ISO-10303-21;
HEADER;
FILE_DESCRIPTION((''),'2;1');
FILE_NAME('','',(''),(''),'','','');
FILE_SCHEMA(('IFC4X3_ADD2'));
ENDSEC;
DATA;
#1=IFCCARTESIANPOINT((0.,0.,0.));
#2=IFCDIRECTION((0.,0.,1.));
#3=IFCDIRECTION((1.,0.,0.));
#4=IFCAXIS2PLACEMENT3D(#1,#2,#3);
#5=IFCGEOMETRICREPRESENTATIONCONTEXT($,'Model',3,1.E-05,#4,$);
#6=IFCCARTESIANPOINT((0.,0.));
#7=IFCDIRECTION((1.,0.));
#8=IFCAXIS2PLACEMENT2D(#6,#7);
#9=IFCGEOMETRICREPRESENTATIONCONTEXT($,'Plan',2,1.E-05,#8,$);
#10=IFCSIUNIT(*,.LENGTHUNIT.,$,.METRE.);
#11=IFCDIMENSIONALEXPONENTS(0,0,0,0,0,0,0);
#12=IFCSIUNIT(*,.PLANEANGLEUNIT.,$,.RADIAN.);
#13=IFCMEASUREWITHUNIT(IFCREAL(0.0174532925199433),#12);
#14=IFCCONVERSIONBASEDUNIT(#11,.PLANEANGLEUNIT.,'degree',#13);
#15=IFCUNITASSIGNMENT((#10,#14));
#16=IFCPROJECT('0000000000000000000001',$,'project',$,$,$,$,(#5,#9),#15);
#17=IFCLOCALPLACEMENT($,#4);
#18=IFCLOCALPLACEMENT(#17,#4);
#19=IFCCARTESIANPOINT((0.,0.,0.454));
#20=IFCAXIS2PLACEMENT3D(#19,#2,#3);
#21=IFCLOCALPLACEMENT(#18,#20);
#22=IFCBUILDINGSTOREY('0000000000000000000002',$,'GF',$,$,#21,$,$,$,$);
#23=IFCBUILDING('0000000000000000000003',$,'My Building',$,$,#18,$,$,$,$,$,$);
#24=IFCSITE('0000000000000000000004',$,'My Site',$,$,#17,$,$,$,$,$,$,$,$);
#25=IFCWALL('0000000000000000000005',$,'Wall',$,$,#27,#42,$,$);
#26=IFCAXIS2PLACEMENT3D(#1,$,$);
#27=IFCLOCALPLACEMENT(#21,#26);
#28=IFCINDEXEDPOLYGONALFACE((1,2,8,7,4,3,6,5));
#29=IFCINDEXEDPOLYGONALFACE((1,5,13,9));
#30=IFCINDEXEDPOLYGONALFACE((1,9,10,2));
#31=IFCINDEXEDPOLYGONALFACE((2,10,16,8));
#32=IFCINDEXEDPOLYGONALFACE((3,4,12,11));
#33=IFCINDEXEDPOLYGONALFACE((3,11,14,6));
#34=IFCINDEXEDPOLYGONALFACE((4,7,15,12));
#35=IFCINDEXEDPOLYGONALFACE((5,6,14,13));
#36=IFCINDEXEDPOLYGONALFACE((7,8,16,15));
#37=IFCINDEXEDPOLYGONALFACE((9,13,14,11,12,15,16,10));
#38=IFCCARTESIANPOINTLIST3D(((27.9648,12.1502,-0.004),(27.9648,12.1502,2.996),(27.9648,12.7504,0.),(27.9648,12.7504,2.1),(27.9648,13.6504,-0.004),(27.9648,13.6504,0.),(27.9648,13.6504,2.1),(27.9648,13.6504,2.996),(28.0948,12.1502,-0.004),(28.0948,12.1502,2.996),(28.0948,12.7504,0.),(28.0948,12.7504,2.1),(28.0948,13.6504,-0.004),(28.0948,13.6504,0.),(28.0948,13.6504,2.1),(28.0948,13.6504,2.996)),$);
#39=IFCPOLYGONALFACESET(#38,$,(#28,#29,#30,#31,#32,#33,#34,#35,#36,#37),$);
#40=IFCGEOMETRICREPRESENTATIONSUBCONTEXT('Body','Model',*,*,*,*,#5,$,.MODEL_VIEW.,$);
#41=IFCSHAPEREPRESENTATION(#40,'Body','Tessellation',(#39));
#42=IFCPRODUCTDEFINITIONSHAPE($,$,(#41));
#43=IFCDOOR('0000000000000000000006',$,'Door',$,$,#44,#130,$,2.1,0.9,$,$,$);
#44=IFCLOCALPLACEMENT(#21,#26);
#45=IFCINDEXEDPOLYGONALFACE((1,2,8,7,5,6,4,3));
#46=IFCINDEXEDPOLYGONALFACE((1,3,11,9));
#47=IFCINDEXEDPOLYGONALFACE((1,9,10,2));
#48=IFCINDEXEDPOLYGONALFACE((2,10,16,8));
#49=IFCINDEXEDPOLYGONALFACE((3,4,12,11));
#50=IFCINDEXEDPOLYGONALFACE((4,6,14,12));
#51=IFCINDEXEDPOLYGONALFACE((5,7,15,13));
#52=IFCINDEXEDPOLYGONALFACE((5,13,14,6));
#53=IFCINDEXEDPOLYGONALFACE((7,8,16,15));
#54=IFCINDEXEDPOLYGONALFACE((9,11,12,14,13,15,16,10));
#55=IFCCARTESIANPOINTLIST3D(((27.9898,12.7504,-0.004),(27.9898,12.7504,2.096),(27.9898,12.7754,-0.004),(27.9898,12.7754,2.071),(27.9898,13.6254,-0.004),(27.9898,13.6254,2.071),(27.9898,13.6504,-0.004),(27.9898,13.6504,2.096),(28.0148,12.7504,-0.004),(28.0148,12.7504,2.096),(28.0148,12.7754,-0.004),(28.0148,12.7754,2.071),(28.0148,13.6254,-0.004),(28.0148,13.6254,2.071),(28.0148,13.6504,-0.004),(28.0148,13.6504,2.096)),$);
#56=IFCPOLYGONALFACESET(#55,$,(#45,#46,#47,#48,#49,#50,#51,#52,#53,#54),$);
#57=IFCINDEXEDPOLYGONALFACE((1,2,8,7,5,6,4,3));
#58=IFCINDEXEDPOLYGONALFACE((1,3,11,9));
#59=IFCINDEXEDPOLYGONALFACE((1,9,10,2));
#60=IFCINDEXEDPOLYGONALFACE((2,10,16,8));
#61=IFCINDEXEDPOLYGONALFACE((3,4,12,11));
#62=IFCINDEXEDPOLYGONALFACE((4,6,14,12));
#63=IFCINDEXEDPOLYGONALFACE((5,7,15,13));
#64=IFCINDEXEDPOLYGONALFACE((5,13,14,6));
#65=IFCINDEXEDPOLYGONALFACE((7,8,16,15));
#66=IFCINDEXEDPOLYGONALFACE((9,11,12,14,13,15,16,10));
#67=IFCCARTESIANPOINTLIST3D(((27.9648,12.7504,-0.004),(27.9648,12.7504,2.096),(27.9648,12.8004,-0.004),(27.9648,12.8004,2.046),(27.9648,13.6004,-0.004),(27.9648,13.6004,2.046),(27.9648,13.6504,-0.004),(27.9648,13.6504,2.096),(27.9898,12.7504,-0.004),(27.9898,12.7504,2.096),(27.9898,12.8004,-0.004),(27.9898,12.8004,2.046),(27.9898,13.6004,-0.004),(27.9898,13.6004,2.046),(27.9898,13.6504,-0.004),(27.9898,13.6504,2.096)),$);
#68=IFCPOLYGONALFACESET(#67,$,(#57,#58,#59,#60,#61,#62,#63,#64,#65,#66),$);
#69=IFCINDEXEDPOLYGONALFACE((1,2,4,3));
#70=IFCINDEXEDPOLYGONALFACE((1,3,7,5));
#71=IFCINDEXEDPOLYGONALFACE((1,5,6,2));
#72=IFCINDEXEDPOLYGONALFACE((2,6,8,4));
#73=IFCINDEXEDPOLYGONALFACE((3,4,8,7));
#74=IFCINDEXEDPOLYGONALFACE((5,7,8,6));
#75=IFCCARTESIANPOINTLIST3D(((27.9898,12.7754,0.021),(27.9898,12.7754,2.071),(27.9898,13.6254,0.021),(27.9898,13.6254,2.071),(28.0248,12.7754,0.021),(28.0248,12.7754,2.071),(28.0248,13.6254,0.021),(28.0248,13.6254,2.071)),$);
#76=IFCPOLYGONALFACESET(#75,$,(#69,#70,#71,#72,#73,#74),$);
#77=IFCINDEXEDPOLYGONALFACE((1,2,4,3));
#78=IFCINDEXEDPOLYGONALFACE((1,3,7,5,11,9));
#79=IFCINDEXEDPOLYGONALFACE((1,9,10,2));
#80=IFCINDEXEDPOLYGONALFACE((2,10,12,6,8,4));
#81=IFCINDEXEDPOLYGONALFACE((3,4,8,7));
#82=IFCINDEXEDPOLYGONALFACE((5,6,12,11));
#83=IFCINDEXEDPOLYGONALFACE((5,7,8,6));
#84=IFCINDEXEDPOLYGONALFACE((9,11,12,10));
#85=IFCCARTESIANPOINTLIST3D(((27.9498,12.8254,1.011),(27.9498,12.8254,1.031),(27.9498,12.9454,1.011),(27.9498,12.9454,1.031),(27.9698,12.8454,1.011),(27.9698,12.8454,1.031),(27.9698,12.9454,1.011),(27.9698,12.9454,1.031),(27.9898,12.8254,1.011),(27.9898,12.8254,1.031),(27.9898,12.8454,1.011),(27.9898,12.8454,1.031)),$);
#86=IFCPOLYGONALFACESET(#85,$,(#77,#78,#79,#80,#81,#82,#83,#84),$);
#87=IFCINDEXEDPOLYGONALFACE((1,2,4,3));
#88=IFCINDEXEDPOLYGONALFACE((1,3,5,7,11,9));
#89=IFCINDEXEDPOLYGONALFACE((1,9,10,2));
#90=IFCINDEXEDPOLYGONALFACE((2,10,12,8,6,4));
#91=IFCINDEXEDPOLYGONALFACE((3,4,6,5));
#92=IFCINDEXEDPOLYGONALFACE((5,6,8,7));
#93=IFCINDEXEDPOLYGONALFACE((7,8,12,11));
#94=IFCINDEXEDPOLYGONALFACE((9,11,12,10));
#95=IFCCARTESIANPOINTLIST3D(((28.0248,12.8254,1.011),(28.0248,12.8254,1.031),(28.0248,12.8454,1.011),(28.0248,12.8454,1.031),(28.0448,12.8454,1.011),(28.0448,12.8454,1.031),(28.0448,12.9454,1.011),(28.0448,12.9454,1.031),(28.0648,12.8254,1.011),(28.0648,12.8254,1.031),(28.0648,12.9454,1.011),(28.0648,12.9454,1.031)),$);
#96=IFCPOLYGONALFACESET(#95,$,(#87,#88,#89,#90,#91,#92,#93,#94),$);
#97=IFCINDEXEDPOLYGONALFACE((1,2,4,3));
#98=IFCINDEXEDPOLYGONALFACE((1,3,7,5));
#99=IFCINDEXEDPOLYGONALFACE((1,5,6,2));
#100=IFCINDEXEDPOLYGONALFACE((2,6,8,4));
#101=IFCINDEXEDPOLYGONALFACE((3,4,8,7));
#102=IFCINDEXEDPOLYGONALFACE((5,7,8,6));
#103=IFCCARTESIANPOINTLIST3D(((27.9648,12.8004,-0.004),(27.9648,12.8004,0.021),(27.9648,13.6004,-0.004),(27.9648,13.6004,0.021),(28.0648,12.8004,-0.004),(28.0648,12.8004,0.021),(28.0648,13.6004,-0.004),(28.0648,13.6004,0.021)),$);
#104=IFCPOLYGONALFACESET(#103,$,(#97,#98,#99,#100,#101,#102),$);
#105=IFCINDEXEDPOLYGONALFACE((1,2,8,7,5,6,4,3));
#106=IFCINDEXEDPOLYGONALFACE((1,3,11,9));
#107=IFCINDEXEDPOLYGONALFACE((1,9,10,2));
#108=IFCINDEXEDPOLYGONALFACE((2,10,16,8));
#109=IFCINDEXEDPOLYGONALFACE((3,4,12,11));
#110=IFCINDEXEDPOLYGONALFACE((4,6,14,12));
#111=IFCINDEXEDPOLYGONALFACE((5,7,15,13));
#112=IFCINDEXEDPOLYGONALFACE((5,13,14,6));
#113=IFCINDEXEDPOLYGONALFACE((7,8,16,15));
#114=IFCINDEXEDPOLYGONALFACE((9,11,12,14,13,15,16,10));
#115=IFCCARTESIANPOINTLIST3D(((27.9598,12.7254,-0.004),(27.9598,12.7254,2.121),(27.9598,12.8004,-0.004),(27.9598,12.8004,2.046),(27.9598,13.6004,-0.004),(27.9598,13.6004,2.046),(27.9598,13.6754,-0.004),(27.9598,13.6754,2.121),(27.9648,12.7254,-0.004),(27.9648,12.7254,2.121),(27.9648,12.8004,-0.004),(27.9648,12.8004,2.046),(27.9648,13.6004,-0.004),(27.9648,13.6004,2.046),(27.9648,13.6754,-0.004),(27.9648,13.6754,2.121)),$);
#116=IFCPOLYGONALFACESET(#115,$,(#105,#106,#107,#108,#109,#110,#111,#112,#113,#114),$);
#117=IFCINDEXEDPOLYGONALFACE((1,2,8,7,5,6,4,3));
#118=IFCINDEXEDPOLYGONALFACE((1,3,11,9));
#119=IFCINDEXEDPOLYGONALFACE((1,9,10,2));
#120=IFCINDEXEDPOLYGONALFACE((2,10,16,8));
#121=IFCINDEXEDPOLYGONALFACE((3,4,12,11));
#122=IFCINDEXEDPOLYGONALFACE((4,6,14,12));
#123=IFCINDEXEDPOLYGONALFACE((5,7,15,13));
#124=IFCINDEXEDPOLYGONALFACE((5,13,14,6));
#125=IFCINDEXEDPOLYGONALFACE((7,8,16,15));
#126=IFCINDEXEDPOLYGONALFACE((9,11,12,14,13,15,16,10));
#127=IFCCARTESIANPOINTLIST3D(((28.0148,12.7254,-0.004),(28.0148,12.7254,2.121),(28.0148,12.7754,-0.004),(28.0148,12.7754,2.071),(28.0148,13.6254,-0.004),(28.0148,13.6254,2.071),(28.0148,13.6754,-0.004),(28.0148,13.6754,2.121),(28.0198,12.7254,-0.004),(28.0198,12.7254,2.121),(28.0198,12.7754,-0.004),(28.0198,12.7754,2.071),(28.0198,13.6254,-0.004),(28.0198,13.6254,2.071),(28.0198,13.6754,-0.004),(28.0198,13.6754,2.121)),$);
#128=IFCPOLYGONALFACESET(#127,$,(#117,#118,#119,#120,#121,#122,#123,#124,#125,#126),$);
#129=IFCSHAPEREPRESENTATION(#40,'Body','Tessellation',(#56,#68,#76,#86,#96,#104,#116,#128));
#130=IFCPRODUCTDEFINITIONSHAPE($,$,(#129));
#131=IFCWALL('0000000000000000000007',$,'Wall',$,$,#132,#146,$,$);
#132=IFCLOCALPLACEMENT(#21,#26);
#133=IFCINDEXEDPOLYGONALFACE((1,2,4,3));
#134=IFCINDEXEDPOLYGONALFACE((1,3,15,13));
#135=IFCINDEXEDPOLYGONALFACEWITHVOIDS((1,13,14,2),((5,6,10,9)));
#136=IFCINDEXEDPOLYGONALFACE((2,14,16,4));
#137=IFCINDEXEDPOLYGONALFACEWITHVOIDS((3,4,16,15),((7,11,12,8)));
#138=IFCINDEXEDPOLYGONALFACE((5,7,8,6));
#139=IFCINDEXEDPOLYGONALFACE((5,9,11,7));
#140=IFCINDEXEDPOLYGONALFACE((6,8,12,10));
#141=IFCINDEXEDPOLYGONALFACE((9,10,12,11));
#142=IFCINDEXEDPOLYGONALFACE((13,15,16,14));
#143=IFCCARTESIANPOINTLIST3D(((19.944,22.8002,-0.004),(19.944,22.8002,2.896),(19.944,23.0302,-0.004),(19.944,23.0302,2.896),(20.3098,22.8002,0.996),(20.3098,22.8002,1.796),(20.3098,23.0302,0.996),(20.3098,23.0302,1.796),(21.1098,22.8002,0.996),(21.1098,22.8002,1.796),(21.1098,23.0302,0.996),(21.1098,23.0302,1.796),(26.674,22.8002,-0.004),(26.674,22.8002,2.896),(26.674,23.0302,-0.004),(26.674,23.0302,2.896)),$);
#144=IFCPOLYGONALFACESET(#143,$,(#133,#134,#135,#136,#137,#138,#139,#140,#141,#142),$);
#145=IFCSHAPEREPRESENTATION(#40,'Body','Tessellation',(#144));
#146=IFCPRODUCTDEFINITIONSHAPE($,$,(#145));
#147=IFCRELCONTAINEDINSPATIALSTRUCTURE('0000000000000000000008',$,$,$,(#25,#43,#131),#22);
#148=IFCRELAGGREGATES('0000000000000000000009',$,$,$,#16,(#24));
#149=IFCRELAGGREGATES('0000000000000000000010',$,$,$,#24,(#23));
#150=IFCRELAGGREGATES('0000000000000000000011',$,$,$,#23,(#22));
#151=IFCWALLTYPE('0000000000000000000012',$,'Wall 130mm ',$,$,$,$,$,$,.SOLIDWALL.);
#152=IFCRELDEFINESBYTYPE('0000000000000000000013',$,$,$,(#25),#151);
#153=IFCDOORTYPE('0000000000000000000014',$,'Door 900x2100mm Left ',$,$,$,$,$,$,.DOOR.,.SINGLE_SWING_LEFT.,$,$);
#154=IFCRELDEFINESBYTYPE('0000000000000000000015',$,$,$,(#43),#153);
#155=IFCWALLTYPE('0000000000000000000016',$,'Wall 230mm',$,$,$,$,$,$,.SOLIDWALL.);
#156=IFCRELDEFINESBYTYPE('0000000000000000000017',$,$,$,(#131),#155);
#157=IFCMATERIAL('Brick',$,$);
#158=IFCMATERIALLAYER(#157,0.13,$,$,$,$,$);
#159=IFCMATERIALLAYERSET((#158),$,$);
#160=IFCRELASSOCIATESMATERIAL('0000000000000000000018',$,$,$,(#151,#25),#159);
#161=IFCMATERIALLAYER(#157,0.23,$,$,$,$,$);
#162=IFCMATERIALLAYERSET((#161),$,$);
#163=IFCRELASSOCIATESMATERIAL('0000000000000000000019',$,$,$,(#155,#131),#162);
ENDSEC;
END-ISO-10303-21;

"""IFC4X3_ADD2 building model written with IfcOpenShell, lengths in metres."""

from ifc_helpers import new_model, entity, si_unit, converted_unit, frame, origin_with_axes, origin_2d_with_axis, place, context, subcontext, project, spatial, line, indexed_curve, outline, extrude, shape, source, transform, mapped, material, layer, layer_set, layer_usage, type_object, type_shapes, element, fill, save


model = new_model("IFC4X3_ADD2")

# Units and contexts
model_context = context("Model", 3, precision=1e-05, world=origin_with_axes())
plan_context = context("Plan", 2, precision=1e-05, world=origin_2d_with_axis())
body_context_1 = subcontext(model_context, "Body", "Model", "MODEL_VIEW")
body_context_2 = subcontext(plan_context, "Body", "Plan", "PLAN_VIEW")
ifc_project = project(units=[si_unit("LENGTHUNIT", "METRE"), converted_unit("PLANEANGLEUNIT", "degree", entity("IfcReal", 0.0174532925199433), si_unit("PLANEANGLEUNIT", "RADIAN"), dimensions=[0, 0, 0, 0, 0, 0, 0])], contexts=[model_context, plan_context])

# Site, building, storey
site_placement = place(None, origin_with_axes())
site = spatial("IfcSite", under=ifc_project, at=site_placement, Name="My Site")
building_placement = place(site_placement, origin_with_axes())
building = spatial("IfcBuilding", under=site, at=building_placement, Name="My Building")
storey_placement = place(building_placement, frame((0.0, 0.0, 0.454), z_axis=(0.0, 0.0, 1.0), x_axis=(1.0, 0.0, 0.0)))
storey = spatial("IfcBuildingStorey", under=building, at=storey_placement, Name="GF")

# Shared definitions
ifc_material_1 = material(Name="Brick")
ifc_layer_1 = layer(ifc_material_1, 0.13)
ifc_layer_set_1 = layer_set([ifc_layer_1])
wall_type_1 = type_object("IfcWallType", Name="Wall 130mm ", PredefinedType="SOLIDWALL", material=ifc_layer_set_1)

# Wall, opening, door
ifc_layer_usage_1 = layer_usage(ifc_layer_set_1, "AXIS2", "POSITIVE", 0.0)
wall_1_placement = place(storey_placement, frame((27.9648, 13.6504, -0.004), z_axis=(0.0, 0.0, 1.0), x_axis=(0.0, -1.0, 0.0)))
wall_1 = element("IfcWall", 1, at=wall_1_placement, inside=storey, type_object=wall_type_1, material=ifc_layer_usage_1, Name="Wall", context=body_context_1, shape_type="SweptSolid", body=[
    extrude(outline(indexed_curve([(0.0, 0.0), (0.0, 0.13), (1.5002, 0.13), (1.5002, 0.0), (0.0, 0.0)], self_intersect=False)), origin_with_axes(), (0.0, 0.0, 1.0), 3.0),
])
shared_shape_1 = source(origin_with_axes(), body_context_1, "Body", "SweptSolid", [
    extrude(outline(indexed_curve([(0.0, 0.0), (0.9, 0.0), (0.9, 2.1), (0.0, 2.1)], segments=[line(1, 2, 3, 4, 1)])), frame((0.0, -0.6, 0.0), z_axis=(0.0, -1.0, 0.0), x_axis=(1.0, 0.0, 0.0)), (0.0, 0.0, -1.0), 1.2),
])
opening_1_placement = place(wall_1_placement, frame((0.0, 0.0, 0.004), z_axis=(0.0, 0.0, 1.0), x_axis=(1.0, 0.0, 0.0)))
opening_1 = element("IfcOpeningElement", 2, at=opening_1_placement, cuts=wall_1, PredefinedType="OPENING", context=body_context_1, shape_type="MappedRepresentation", body=[
    mapped(shared_shape_1, transform((0.0, 0.0, 0.0), x_axis=(1.0, 0.0, 0.0), y_axis=(0.0, 1.0, 0.0), z_axis=(0.0, 0.0, 1.0), scale=1.0)),
])
door_type_1 = type_object("IfcDoorType", Name="Door 900x2100mm Left ", OperationType="SINGLE_SWING_LEFT", PredefinedType="DOOR")
shared_shape_2 = source(origin_with_axes(), body_context_1, "Body", "SweptSolid", [
    extrude(outline(indexed_curve([(0.0, 0.0), (0.0, 2.1), (0.9, 2.1), (0.9, 0.0), (0.875, 0.0), (0.875, 2.075), (0.025, 2.075), (0.025, 0.0)], segments=[line(1, 2, 3, 4, 5, 6, 7, 8, 1)])), frame((0.0, 0.025, 0.0), z_axis=(0.0, -1.0, 0.0), x_axis=(1.0, 0.0, 0.0)), (0.0, 0.0, -1.0), 0.025),
    extrude(outline(indexed_curve([(0.0, 0.0), (0.0, 2.1), (0.9, 2.1), (0.9, 0.0), (0.85, 0.0), (0.85, 2.05), (0.05, 2.05), (0.05, 0.0)], segments=[line(1, 2, 3, 4, 5, 6, 7, 8, 1)])), frame((0.0, 0.0, 0.0), z_axis=(0.0, -1.0, 0.0), x_axis=(1.0, 0.0, 0.0)), (0.0, 0.0, -1.0), 0.025),
    extrude(outline(indexed_curve([(0.0, 0.0), (0.85, 0.0), (0.85, 0.035), (0.0, 0.035)], segments=[line(1, 2, 3, 4, 1)])), frame((0.025, 0.025, 0.025), z_axis=(0.0, 0.0, 1.0), x_axis=(1.0, 0.0, 0.0)), (0.0, 0.0, 1.0), 2.05),
    extrude(outline(indexed_curve([(0.0, 0.0), (0.0, -0.04), (-0.12, -0.04), (-0.12, -0.02), (-0.02, -0.02), (-0.02, 0.0)], segments=[line(1, 2, 3, 4, 5, 6, 1)])), frame((0.825, 0.025, 1.015), z_axis=(0.0, 0.0, 1.0), x_axis=(1.0, 0.0, 0.0)), (0.0, 0.0, 1.0), 0.02),
    extrude(outline(indexed_curve([(0.0, 0.0), (0.0, 0.04), (-0.12, 0.04), (-0.12, 0.02), (-0.02, 0.02), (-0.02, 0.0)], segments=[line(1, 2, 3, 4, 5, 6, 1)])), frame((0.825, 0.06, 1.015), z_axis=(0.0, 0.0, 1.0), x_axis=(1.0, 0.0, 0.0)), (0.0, 0.0, 1.0), 0.02),
    extrude(outline(indexed_curve([(0.0, 0.0), (0.8, 0.0), (0.8, 0.1), (0.0, 0.1)], segments=[line(1, 2, 3, 4, 1)])), frame((0.05, 0.0, 0.0), z_axis=(0.0, 0.0, 1.0), x_axis=(1.0, 0.0, 0.0)), (0.0, 0.0, 1.0), 0.025),
    extrude(outline(indexed_curve([(0.0, 0.0), (0.0, 2.125), (0.95, 2.125), (0.95, 0.0), (0.875, 0.0), (0.875, 2.05), (0.075, 2.05), (0.075, 0.0)], segments=[line(1, 2, 3, 4, 5, 6, 7, 8, 1)])), frame((-0.025, -0.005, 0.0), z_axis=(0.0, -1.0, 0.0), x_axis=(1.0, 0.0, 0.0)), (0.0, 0.0, -1.0), 0.005),
    extrude(outline(indexed_curve([(0.0, 0.0), (0.0, 2.125), (0.95, 2.125), (0.95, 0.0), (0.9, 0.0), (0.9, 2.075), (0.05, 2.075), (0.05, 0.0)], segments=[line(1, 2, 3, 4, 5, 6, 7, 8, 1)])), frame((-0.025, 0.05, 0.0), z_axis=(0.0, -1.0, 0.0), x_axis=(1.0, 0.0, 0.0)), (0.0, 0.0, -1.0), 0.005),
])
shared_shape_3 = source(origin_with_axes(), body_context_2, "Body", "Curve2D", [
    entity("IfcIndexedPolyCurve", entity("IfcCartesianPointList2D", [[0.0, 0.0], [0.0, 0.05], [0.025, 0.05], [0.025, 0.025], [0.05, 0.025], [0.05, 0.0]]), [entity("IfcLineIndex", [1, 2, 3, 4, 5, 6, 1])]),
    entity("IfcIndexedPolyCurve", entity("IfcCartesianPointList2D", [[0.9, 0.0], [0.9, 0.05], [0.875, 0.05], [0.875, 0.025], [0.85, 0.025], [0.85, 0.0]]), [entity("IfcLineIndex", [1, 2, 3, 4, 5, 6, 1])]),
    entity("IfcTrimmedCurve", entity("IfcEllipse", entity("IfcAxis2Placement2D", entity("IfcCartesianPoint", [0.06, 0.05]), entity("IfcDirection", [1.0, 0.0])), 0.815, 0.85), [entity("IfcCartesianPoint", [0.875, 0.05])], [entity("IfcCartesianPoint", [0.06, 0.9])], True, "CARTESIAN"),
    entity("IfcIndexedPolyCurve", entity("IfcCartesianPointList2D", [[0.025, 0.05], [0.06, 0.05], [0.06, 0.9], [0.025, 0.9]]), [entity("IfcLineIndex", [1, 2, 3, 4, 1])]),
])
type_shapes(door_type_1, [shared_shape_2, shared_shape_3])
door_1_placement = place(opening_1_placement, frame((0.0, 0.0, -0.004), z_axis=(0.0, 0.0, 1.0), x_axis=(1.0, 0.0, 0.0)))
door_1 = element("IfcDoor", 3, at=door_1_placement, inside=storey, type_object=door_type_1, Name="Door", OverallHeight=2.1, OverallWidth=0.9, shapes=[
    shape(body_context_1, "Body", "MappedRepresentation", [mapped(shared_shape_2, transform((0.0, 0.0, 0.0), x_axis=(1.0, 0.0, 0.0), y_axis=(0.0, 1.0, 0.0), z_axis=(0.0, 0.0, 1.0), scale=1.0))]),
    shape(body_context_2, "Body", "MappedRepresentation", [mapped(shared_shape_3, transform((0.0, 0.0, 0.0), x_axis=(1.0, 0.0, 0.0), y_axis=(0.0, 1.0, 0.0), z_axis=(0.0, 0.0, 1.0), scale=1.0))]),
])
fill(opening_1, door_1)

# Wall, opening
ifc_layer_2 = layer(ifc_material_1, 0.23)
ifc_layer_set_2 = layer_set([ifc_layer_2])
ifc_layer_usage_2 = layer_usage(ifc_layer_set_2, "AXIS2", "POSITIVE", 0.0)
wall_type_2 = type_object("IfcWallType", Name="Wall 230mm", PredefinedType="SOLIDWALL", material=ifc_layer_set_2)
wall_2_placement = place(storey_placement, frame((26.674, 23.0302, -0.004), z_axis=(0.0, 0.0, 1.0), x_axis=(-1.0, 0.0, 0.0)))
wall_2 = element("IfcWall", 4, at=wall_2_placement, inside=storey, type_object=wall_type_2, material=ifc_layer_usage_2, Name="Wall", context=body_context_1, shape_type="SweptSolid", body=[
    extrude(outline(indexed_curve([(0.0, 0.0), (0.0, 0.23), (6.73, 0.23), (6.73, 0.0), (0.0, 0.0)], self_intersect=False)), origin_with_axes(), (0.0, 0.0, 1.0), 2.9),
])
shared_shape_4 = source(origin_with_axes(), body_context_1, "Body", "SweptSolid", [
    extrude(outline(indexed_curve([(0.0, 0.0), (0.8, 0.0), (0.8, 0.8), (0.0, 0.8)], segments=[line(1, 2, 3, 4, 1)])), frame((-0.4, -0.6, 0.0), z_axis=(0.0, -1.0, 0.0), x_axis=(1.0, 0.0, 0.0)), (0.0, 0.0, -1.0), 1.2),
])
opening_2_placement = place(wall_2_placement, frame((5.9642, 0.0, 1.0), z_axis=(0.0, 0.0, 1.0), x_axis=(1.0, 0.0, 0.0)))
element("IfcOpeningElement", 5, at=opening_2_placement, cuts=wall_2, PredefinedType="OPENING", context=body_context_1, shape_type="MappedRepresentation", body=[
    mapped(shared_shape_4, transform((0.0, 0.0, 0.0), x_axis=(1.0, 0.0, 0.0), y_axis=(0.0, 1.0, 0.0), z_axis=(0.0, 0.0, 1.0), scale=1.0)),
])

save(model, "model.ifc")
